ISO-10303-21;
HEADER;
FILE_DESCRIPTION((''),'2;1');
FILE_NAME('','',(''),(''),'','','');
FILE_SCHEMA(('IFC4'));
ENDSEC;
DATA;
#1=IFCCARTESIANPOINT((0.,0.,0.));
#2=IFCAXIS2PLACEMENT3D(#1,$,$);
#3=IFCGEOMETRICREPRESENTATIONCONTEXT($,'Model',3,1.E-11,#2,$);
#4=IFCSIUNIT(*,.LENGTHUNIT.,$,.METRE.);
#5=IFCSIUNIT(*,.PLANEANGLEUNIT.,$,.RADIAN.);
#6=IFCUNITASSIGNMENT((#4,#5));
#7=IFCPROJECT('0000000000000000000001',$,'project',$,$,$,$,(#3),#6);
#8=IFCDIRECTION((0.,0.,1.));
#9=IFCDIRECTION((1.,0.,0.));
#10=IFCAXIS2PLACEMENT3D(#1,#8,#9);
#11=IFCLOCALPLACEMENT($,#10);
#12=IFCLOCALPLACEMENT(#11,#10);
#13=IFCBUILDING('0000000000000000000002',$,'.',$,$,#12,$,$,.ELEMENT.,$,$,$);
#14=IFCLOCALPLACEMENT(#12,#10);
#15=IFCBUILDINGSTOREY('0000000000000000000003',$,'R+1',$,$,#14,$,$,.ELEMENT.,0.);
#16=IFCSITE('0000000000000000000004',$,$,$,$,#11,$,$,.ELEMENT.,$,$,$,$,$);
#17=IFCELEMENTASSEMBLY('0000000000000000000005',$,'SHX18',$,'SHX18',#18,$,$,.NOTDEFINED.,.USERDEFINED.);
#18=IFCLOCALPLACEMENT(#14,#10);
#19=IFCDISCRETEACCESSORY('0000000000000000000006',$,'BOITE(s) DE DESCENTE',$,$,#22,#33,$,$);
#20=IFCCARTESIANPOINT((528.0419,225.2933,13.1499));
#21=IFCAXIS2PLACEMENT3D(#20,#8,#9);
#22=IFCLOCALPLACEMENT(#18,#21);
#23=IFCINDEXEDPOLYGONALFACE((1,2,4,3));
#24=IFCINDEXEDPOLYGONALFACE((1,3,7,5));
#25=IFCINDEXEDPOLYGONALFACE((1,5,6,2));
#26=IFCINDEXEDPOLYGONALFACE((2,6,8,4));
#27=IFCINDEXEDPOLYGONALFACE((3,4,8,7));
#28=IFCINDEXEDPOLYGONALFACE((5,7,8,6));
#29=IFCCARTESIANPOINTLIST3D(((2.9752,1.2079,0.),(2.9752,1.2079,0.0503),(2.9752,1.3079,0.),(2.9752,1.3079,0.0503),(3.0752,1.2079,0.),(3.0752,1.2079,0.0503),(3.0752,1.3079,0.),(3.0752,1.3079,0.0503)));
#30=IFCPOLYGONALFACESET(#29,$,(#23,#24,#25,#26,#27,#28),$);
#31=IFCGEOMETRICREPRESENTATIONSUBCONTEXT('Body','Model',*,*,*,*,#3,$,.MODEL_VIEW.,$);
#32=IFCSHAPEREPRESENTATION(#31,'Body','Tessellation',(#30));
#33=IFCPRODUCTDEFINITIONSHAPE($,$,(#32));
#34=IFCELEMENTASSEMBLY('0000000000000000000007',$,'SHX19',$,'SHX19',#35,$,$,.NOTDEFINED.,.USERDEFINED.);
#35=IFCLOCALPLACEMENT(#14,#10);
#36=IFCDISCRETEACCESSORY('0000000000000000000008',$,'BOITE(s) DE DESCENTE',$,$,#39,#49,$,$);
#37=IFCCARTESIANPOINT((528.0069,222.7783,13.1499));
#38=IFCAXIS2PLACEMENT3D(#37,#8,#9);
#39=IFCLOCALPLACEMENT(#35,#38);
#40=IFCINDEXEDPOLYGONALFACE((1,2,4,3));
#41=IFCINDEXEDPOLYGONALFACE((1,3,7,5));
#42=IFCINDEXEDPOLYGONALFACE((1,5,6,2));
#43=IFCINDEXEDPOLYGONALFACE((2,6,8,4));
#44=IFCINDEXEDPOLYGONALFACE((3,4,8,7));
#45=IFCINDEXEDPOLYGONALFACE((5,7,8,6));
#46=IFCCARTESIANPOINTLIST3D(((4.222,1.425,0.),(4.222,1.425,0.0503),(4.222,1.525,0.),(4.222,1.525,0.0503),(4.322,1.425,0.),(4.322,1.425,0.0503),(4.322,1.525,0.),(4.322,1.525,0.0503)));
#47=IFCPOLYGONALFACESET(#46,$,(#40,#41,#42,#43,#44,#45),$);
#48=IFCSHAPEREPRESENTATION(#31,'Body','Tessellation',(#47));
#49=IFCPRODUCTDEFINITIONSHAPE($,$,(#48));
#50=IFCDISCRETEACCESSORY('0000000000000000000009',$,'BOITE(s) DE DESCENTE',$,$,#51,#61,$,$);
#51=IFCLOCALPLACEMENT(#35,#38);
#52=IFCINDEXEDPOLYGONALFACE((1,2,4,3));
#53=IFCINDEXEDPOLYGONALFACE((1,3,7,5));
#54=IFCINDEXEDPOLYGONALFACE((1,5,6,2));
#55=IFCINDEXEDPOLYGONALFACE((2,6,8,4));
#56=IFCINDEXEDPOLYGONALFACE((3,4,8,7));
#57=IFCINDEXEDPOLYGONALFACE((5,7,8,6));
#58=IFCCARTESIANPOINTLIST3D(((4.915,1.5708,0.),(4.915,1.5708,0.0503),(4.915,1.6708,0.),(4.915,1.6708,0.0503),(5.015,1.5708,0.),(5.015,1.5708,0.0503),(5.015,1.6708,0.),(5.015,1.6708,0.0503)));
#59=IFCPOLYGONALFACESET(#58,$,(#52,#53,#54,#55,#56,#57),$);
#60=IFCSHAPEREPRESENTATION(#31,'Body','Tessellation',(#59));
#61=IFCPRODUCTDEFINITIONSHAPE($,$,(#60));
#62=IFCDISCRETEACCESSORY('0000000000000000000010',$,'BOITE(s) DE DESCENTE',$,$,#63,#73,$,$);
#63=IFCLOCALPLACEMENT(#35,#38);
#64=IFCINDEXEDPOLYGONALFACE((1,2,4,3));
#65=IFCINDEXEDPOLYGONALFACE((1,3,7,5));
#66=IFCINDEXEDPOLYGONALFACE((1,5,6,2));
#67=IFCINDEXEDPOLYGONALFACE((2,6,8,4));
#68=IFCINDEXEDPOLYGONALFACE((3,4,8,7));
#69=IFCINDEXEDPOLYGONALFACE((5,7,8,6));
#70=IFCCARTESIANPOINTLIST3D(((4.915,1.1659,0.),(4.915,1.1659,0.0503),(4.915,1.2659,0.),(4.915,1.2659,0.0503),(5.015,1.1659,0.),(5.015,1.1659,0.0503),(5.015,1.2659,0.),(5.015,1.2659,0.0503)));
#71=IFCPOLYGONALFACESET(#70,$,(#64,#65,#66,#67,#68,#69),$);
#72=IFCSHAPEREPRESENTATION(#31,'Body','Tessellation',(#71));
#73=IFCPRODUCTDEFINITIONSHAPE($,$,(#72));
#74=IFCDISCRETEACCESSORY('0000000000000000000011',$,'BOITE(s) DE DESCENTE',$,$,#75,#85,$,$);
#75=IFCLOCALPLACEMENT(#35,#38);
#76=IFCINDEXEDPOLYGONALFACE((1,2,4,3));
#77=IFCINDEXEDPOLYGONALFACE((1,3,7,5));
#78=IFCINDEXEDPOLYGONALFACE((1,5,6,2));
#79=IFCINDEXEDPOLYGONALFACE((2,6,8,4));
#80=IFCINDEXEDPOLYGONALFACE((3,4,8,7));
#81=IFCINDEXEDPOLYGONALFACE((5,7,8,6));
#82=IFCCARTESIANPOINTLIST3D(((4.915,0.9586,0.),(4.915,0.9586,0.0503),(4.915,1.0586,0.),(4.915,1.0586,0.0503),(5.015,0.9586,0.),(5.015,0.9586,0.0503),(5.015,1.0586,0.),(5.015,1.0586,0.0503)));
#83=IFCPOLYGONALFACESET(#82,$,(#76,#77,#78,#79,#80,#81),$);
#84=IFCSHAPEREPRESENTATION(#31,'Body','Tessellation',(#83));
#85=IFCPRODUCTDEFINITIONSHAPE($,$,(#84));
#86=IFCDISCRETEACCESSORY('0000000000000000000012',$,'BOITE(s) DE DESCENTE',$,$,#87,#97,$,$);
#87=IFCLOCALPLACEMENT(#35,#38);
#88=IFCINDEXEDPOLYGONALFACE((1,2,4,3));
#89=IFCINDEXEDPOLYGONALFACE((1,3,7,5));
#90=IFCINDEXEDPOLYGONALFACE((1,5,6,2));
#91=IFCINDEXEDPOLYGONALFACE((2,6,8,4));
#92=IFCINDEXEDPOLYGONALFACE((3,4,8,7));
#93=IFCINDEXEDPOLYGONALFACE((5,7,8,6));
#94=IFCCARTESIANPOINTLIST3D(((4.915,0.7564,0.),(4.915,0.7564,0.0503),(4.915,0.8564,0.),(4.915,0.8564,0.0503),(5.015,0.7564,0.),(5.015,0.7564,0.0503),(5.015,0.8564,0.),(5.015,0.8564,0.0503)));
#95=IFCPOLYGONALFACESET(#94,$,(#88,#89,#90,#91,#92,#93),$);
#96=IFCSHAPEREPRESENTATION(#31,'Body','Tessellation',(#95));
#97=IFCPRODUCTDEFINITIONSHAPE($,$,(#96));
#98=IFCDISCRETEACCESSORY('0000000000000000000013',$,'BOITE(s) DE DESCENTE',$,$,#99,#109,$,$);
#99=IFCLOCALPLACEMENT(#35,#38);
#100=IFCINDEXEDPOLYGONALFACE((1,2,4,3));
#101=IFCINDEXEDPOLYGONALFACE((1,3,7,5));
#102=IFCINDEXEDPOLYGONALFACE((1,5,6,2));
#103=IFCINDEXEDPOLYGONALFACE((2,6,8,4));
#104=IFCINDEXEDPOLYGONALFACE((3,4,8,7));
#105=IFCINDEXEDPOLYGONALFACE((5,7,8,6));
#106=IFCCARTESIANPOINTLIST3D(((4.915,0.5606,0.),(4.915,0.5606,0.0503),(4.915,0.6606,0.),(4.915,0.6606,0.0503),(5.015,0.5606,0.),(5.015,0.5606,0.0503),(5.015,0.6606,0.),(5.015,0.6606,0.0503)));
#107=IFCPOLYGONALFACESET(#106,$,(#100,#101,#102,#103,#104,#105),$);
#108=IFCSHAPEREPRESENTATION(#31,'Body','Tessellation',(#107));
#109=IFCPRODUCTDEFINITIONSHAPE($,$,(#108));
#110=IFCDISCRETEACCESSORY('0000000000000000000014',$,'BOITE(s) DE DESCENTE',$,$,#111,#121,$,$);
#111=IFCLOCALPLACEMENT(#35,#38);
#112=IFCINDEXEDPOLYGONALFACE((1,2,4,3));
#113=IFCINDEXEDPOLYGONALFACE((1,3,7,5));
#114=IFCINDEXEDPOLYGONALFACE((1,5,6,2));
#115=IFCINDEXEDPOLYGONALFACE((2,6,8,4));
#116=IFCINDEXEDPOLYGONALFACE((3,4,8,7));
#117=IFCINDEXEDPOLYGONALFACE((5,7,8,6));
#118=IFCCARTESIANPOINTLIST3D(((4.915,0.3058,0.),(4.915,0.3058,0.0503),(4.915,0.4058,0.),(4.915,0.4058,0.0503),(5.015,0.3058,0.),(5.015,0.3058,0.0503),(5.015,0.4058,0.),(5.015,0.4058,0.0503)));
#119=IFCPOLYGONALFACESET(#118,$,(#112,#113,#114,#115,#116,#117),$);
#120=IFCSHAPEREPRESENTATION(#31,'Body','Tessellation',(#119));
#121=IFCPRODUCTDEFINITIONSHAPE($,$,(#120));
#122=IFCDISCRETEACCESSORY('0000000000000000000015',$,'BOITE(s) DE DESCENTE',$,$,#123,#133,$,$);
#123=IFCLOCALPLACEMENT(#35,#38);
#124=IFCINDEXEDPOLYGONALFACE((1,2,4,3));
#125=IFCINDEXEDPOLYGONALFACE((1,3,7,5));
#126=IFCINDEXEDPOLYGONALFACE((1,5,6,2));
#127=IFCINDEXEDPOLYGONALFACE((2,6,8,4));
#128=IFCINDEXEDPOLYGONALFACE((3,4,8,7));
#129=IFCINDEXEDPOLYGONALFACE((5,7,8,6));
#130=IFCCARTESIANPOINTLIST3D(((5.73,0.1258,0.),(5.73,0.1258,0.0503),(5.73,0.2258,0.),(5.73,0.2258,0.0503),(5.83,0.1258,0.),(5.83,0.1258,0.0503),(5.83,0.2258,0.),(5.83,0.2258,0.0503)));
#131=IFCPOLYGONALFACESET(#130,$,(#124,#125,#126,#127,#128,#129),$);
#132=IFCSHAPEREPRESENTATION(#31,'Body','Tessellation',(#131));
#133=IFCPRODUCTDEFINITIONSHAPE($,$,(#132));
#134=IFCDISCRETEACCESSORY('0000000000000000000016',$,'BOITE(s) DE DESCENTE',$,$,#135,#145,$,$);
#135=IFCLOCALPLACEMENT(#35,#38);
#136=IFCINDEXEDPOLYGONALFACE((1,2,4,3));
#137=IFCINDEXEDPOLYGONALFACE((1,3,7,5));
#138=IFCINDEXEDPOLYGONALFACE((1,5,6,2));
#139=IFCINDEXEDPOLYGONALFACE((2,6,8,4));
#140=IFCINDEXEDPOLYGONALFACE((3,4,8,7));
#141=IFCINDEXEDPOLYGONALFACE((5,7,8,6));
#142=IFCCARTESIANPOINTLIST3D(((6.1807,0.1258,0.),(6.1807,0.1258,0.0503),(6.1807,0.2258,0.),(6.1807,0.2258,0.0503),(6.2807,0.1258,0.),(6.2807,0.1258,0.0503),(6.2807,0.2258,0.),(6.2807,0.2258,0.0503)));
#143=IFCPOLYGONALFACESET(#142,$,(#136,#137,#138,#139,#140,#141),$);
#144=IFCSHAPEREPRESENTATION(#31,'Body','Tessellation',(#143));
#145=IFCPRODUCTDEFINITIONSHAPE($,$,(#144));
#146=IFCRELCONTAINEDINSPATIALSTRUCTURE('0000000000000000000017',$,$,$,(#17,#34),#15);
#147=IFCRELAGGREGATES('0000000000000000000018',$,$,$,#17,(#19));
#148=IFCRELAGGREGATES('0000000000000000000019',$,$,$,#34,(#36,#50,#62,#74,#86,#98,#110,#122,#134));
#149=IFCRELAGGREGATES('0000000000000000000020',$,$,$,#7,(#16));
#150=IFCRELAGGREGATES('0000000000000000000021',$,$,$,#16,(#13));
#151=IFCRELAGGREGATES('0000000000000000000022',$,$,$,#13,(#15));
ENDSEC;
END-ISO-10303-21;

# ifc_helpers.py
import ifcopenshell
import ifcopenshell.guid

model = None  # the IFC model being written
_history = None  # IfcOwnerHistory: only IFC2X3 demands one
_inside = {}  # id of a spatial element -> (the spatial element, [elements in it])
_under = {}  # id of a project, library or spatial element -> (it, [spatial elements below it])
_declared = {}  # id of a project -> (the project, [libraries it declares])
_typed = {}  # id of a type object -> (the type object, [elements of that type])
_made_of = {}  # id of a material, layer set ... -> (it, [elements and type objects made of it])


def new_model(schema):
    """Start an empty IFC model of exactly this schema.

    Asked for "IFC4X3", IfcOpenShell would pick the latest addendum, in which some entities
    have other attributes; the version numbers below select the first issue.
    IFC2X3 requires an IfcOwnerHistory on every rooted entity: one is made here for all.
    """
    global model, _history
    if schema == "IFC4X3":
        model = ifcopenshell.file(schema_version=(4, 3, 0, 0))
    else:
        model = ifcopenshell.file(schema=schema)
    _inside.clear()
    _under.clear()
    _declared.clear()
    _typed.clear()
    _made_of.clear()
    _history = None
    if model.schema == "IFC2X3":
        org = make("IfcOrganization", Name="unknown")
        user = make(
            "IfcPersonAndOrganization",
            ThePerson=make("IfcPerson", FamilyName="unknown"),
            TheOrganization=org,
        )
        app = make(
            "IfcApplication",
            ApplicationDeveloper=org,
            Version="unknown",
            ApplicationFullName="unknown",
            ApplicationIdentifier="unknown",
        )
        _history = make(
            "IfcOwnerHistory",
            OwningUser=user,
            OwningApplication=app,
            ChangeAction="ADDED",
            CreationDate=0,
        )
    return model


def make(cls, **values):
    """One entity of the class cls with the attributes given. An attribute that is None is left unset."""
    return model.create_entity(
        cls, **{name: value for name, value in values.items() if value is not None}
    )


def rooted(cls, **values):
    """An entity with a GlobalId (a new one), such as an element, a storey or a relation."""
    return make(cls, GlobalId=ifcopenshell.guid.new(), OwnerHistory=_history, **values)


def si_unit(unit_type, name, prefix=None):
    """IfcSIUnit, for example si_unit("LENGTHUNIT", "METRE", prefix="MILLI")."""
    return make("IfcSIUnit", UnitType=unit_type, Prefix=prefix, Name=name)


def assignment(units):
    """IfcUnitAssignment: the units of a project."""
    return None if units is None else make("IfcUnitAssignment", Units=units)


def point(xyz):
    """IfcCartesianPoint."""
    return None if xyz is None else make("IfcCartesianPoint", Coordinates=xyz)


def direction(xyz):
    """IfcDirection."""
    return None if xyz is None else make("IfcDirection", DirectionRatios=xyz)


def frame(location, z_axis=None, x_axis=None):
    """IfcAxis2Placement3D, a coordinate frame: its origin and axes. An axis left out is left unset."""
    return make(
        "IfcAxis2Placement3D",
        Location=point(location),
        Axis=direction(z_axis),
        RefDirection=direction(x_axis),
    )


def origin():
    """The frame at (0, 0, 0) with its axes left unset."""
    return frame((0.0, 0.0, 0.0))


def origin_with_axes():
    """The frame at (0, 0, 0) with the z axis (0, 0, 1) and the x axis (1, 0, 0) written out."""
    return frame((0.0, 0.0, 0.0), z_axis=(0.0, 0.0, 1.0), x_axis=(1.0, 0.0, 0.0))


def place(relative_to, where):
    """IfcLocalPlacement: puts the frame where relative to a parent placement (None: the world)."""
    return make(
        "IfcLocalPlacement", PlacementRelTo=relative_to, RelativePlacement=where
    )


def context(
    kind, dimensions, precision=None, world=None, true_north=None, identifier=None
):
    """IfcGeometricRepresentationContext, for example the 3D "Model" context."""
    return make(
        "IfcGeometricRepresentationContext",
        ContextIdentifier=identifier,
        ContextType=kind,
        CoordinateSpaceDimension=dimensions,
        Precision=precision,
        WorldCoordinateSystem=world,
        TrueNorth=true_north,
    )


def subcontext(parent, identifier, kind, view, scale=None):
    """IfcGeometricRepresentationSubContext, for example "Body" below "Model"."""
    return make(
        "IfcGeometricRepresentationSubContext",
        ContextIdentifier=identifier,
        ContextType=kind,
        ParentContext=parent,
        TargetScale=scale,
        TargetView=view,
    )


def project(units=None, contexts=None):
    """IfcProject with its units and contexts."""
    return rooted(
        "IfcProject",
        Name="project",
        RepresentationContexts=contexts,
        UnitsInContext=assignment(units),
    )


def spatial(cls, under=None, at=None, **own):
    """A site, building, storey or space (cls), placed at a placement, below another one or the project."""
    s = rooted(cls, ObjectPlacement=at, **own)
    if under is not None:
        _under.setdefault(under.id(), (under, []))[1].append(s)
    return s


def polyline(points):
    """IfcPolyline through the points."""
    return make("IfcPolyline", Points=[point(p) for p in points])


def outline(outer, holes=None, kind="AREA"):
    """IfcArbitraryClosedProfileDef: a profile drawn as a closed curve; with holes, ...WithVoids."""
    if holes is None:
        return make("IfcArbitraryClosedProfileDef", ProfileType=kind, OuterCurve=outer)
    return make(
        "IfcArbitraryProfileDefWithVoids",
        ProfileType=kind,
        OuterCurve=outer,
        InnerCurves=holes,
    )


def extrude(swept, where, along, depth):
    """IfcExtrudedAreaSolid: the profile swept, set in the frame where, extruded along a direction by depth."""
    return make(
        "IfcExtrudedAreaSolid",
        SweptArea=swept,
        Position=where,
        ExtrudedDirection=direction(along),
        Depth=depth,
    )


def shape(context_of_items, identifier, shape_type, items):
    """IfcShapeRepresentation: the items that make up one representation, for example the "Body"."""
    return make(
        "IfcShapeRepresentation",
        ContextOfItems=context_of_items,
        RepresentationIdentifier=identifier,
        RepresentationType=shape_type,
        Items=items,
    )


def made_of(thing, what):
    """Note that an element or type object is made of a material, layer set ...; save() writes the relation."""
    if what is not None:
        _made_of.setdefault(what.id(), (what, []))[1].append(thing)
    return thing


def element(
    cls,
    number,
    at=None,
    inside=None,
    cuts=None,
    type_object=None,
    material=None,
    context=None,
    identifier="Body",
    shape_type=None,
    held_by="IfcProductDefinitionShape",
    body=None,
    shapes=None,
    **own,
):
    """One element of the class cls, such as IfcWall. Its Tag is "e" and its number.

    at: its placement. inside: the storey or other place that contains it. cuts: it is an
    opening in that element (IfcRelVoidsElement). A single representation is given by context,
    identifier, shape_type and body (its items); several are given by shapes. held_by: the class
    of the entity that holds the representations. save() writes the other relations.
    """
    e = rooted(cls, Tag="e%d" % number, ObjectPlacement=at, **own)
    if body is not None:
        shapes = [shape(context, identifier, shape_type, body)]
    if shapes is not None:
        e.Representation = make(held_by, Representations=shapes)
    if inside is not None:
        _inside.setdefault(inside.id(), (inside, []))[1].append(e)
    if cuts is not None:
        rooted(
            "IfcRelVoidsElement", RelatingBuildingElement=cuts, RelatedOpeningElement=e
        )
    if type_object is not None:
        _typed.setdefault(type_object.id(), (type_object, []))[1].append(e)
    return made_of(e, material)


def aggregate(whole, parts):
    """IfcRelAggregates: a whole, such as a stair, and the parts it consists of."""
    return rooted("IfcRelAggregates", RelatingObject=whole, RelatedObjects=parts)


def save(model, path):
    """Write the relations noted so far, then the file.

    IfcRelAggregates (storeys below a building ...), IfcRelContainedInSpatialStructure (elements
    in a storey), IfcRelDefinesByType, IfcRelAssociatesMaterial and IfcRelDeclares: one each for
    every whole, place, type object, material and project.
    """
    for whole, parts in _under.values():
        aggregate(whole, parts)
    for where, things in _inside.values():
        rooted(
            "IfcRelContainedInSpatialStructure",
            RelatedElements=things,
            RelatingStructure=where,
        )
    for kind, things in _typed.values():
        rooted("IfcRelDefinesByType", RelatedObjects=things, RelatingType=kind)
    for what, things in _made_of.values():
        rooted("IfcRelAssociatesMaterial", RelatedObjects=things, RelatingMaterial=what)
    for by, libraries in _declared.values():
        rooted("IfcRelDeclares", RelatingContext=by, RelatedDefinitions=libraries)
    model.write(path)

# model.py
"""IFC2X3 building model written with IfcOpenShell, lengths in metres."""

from ifc_helpers import new_model, si_unit, frame, origin, origin_with_axes, place, context, subcontext, project, spatial, polyline, outline, extrude, element, aggregate, save


model = new_model("IFC2X3")

# Units and contexts
model_context = context("Model", 3, precision=1e-11, world=origin())
body_context = subcontext(model_context, "Body", "Model", "MODEL_VIEW")
ifc_project = project(units=[si_unit("LENGTHUNIT", "METRE"), si_unit("PLANEANGLEUNIT", "RADIAN")], contexts=[model_context])

# Site, building, storey
site_placement = place(None, origin_with_axes())
site = spatial("IfcSite", under=ifc_project, at=site_placement, CompositionType="ELEMENT")
building_placement = place(site_placement, origin_with_axes())
building = spatial("IfcBuilding", under=site, at=building_placement, Name=".", CompositionType="ELEMENT")
storey_placement = place(building_placement, origin_with_axes())
storey = spatial("IfcBuildingStorey", under=building, at=storey_placement, Name="R+1", CompositionType="ELEMENT", Elevation=0.0)

# Element assembly
assembly_1_placement = place(storey_placement, origin_with_axes())
assembly_1 = element("IfcElementAssembly", 1, at=assembly_1_placement, inside=storey, Name="SHX18", ObjectType="SHX18", AssemblyPlace="NOTDEFINED", PredefinedType="USERDEFINED")

# Discrete accessory
discrete_accessory_1_placement = place(assembly_1_placement, frame((528.0419, 225.2933, 13.1499), z_axis=(0.0, 0.0, 1.0), x_axis=(1.0, 0.0, 0.0)))
discrete_accessory_1 = element("IfcDiscreteAccessory", 2, at=discrete_accessory_1_placement, Name="BOITE(s) DE DESCENTE", context=body_context, shape_type="SweptSolid", body=[
    extrude(outline(polyline([(1.2079, -2.9752), (1.2079, -3.0752), (1.3079, -3.0752), (1.3079, -2.9752), (1.2079, -2.9752)])), frame((0.0, 0.0, 0.0), z_axis=(0.0, 0.0, 1.0), x_axis=(0.0, 1.0, 0.0)), (0.0, 0.0, 1.0), 0.0503),
])

aggregate(assembly_1, [discrete_accessory_1])

# Element assembly, discrete accessories
assembly_2_placement = place(storey_placement, origin_with_axes())
assembly_2 = element("IfcElementAssembly", 3, at=assembly_2_placement, inside=storey, Name="SHX19", ObjectType="SHX19", AssemblyPlace="NOTDEFINED", PredefinedType="USERDEFINED")
discrete_accessory_2_placement = place(assembly_2_placement, frame((528.0069, 222.7783, 13.1499), z_axis=(0.0, 0.0, 1.0), x_axis=(1.0, 0.0, 0.0)))
discrete_accessory_2 = element("IfcDiscreteAccessory", 4, at=discrete_accessory_2_placement, Name="BOITE(s) DE DESCENTE", context=body_context, shape_type="SweptSolid", body=[
    extrude(outline(polyline([(1.425, -4.222), (1.425, -4.322), (1.525, -4.322), (1.525, -4.222), (1.425, -4.222)])), frame((0.0, 0.0, 0.0), z_axis=(0.0, 0.0, 1.0), x_axis=(0.0, 1.0, 0.0)), (0.0, 0.0, 1.0), 0.0503),
])
discrete_accessory_3_placement = place(assembly_2_placement, frame((528.0069, 222.7783, 13.1499), z_axis=(0.0, 0.0, 1.0), x_axis=(1.0, 0.0, 0.0)))
discrete_accessory_3 = element("IfcDiscreteAccessory", 5, at=discrete_accessory_3_placement, Name="BOITE(s) DE DESCENTE", context=body_context, shape_type="SweptSolid", body=[
    extrude(outline(polyline([(1.5708, -4.915), (1.5708, -5.015), (1.6708, -5.015), (1.6708, -4.915), (1.5708, -4.915)])), frame((0.0, 0.0, 0.0), z_axis=(0.0, 0.0, 1.0), x_axis=(0.0, 1.0, 0.0)), (0.0, 0.0, 1.0), 0.0503),
])
discrete_accessory_4_placement = place(assembly_2_placement, frame((528.0069, 222.7783, 13.1499), z_axis=(0.0, 0.0, 1.0), x_axis=(1.0, 0.0, 0.0)))
discrete_accessory_4 = element("IfcDiscreteAccessory", 6, at=discrete_accessory_4_placement, Name="BOITE(s) DE DESCENTE", context=body_context, shape_type="SweptSolid", body=[
    extrude(outline(polyline([(1.1659, -4.915), (1.1659, -5.015), (1.2659, -5.015), (1.2659, -4.915), (1.1659, -4.915)])), frame((0.0, 0.0, 0.0), z_axis=(0.0, 0.0, 1.0), x_axis=(0.0, 1.0, 0.0)), (0.0, 0.0, 1.0), 0.0503),
])
discrete_accessory_5_placement = place(assembly_2_placement, frame((528.0069, 222.7783, 13.1499), z_axis=(0.0, 0.0, 1.0), x_axis=(1.0, 0.0, 0.0)))
discrete_accessory_5 = element("IfcDiscreteAccessory", 7, at=discrete_accessory_5_placement, Name="BOITE(s) DE DESCENTE", context=body_context, shape_type="SweptSolid", body=[
    extrude(outline(polyline([(0.9586, -4.915), (0.9586, -5.015), (1.0586, -5.015), (1.0586, -4.915), (0.9586, -4.915)])), frame((0.0, 0.0, 0.0), z_axis=(0.0, 0.0, 1.0), x_axis=(0.0, 1.0, 0.0)), (0.0, 0.0, 1.0), 0.0503),
])
discrete_accessory_6_placement = place(assembly_2_placement, frame((528.0069, 222.7783, 13.1499), z_axis=(0.0, 0.0, 1.0), x_axis=(1.0, 0.0, 0.0)))
discrete_accessory_6 = element("IfcDiscreteAccessory", 8, at=discrete_accessory_6_placement, Name="BOITE(s) DE DESCENTE", context=body_context, shape_type="SweptSolid", body=[
    extrude(outline(polyline([(0.7564, -4.915), (0.7564, -5.015), (0.8564, -5.015), (0.8564, -4.915), (0.7564, -4.915)])), frame((0.0, 0.0, 0.0), z_axis=(0.0, 0.0, 1.0), x_axis=(0.0, 1.0, 0.0)), (0.0, 0.0, 1.0), 0.0503),
])
discrete_accessory_7_placement = place(assembly_2_placement, frame((528.0069, 222.7783, 13.1499), z_axis=(0.0, 0.0, 1.0), x_axis=(1.0, 0.0, 0.0)))
discrete_accessory_7 = element("IfcDiscreteAccessory", 9, at=discrete_accessory_7_placement, Name="BOITE(s) DE DESCENTE", context=body_context, shape_type="SweptSolid", body=[
    extrude(outline(polyline([(0.5606, -4.915), (0.5606, -5.015), (0.6606, -5.015), (0.6606, -4.915), (0.5606, -4.915)])), frame((0.0, 0.0, 0.0), z_axis=(0.0, 0.0, 1.0), x_axis=(0.0, 1.0, 0.0)), (0.0, 0.0, 1.0), 0.0503),
])
discrete_accessory_8_placement = place(assembly_2_placement, frame((528.0069, 222.7783, 13.1499), z_axis=(0.0, 0.0, 1.0), x_axis=(1.0, 0.0, 0.0)))
discrete_accessory_8 = element("IfcDiscreteAccessory", 10, at=discrete_accessory_8_placement, Name="BOITE(s) DE DESCENTE", context=body_context, shape_type="SweptSolid", body=[
    extrude(outline(polyline([(0.3058, -4.915), (0.3058, -5.015), (0.4058, -5.015), (0.4058, -4.915), (0.3058, -4.915)])), frame((0.0, 0.0, 0.0), z_axis=(0.0, 0.0, 1.0), x_axis=(0.0, 1.0, 0.0)), (0.0, 0.0, 1.0), 0.0503),
])
discrete_accessory_9_placement = place(assembly_2_placement, frame((528.0069, 222.7783, 13.1499), z_axis=(0.0, 0.0, 1.0), x_axis=(1.0, 0.0, 0.0)))
discrete_accessory_9 = element("IfcDiscreteAccessory", 11, at=discrete_accessory_9_placement, Name="BOITE(s) DE DESCENTE", context=body_context, shape_type="SweptSolid", body=[
    extrude(outline(polyline([(0.1258, -5.73), (0.1258, -5.83), (0.2258, -5.83), (0.2258, -5.73), (0.1258, -5.73)])), frame((0.0, 0.0, 0.0), z_axis=(0.0, 0.0, 1.0), x_axis=(0.0, 1.0, 0.0)), (0.0, 0.0, 1.0), 0.0503),
])
discrete_accessory_10_placement = place(assembly_2_placement, frame((528.0069, 222.7783, 13.1499), z_axis=(0.0, 0.0, 1.0), x_axis=(1.0, 0.0, 0.0)))
discrete_accessory_10 = element("IfcDiscreteAccessory", 12, at=discrete_accessory_10_placement, Name="BOITE(s) DE DESCENTE", context=body_context, shape_type="SweptSolid", body=[
    extrude(outline(polyline([(0.1258, -6.1807), (0.1258, -6.2807), (0.2258, -6.2807), (0.2258, -6.1807), (0.1258, -6.1807)])), frame((0.0, 0.0, 0.0), z_axis=(0.0, 0.0, 1.0), x_axis=(0.0, 1.0, 0.0)), (0.0, 0.0, 1.0), 0.0503),
])
aggregate(assembly_2, [discrete_accessory_2, discrete_accessory_3, discrete_accessory_4, discrete_accessory_5, discrete_accessory_6, discrete_accessory_7, discrete_accessory_8, discrete_accessory_9, discrete_accessory_10])

save(model, "model.ifc")
